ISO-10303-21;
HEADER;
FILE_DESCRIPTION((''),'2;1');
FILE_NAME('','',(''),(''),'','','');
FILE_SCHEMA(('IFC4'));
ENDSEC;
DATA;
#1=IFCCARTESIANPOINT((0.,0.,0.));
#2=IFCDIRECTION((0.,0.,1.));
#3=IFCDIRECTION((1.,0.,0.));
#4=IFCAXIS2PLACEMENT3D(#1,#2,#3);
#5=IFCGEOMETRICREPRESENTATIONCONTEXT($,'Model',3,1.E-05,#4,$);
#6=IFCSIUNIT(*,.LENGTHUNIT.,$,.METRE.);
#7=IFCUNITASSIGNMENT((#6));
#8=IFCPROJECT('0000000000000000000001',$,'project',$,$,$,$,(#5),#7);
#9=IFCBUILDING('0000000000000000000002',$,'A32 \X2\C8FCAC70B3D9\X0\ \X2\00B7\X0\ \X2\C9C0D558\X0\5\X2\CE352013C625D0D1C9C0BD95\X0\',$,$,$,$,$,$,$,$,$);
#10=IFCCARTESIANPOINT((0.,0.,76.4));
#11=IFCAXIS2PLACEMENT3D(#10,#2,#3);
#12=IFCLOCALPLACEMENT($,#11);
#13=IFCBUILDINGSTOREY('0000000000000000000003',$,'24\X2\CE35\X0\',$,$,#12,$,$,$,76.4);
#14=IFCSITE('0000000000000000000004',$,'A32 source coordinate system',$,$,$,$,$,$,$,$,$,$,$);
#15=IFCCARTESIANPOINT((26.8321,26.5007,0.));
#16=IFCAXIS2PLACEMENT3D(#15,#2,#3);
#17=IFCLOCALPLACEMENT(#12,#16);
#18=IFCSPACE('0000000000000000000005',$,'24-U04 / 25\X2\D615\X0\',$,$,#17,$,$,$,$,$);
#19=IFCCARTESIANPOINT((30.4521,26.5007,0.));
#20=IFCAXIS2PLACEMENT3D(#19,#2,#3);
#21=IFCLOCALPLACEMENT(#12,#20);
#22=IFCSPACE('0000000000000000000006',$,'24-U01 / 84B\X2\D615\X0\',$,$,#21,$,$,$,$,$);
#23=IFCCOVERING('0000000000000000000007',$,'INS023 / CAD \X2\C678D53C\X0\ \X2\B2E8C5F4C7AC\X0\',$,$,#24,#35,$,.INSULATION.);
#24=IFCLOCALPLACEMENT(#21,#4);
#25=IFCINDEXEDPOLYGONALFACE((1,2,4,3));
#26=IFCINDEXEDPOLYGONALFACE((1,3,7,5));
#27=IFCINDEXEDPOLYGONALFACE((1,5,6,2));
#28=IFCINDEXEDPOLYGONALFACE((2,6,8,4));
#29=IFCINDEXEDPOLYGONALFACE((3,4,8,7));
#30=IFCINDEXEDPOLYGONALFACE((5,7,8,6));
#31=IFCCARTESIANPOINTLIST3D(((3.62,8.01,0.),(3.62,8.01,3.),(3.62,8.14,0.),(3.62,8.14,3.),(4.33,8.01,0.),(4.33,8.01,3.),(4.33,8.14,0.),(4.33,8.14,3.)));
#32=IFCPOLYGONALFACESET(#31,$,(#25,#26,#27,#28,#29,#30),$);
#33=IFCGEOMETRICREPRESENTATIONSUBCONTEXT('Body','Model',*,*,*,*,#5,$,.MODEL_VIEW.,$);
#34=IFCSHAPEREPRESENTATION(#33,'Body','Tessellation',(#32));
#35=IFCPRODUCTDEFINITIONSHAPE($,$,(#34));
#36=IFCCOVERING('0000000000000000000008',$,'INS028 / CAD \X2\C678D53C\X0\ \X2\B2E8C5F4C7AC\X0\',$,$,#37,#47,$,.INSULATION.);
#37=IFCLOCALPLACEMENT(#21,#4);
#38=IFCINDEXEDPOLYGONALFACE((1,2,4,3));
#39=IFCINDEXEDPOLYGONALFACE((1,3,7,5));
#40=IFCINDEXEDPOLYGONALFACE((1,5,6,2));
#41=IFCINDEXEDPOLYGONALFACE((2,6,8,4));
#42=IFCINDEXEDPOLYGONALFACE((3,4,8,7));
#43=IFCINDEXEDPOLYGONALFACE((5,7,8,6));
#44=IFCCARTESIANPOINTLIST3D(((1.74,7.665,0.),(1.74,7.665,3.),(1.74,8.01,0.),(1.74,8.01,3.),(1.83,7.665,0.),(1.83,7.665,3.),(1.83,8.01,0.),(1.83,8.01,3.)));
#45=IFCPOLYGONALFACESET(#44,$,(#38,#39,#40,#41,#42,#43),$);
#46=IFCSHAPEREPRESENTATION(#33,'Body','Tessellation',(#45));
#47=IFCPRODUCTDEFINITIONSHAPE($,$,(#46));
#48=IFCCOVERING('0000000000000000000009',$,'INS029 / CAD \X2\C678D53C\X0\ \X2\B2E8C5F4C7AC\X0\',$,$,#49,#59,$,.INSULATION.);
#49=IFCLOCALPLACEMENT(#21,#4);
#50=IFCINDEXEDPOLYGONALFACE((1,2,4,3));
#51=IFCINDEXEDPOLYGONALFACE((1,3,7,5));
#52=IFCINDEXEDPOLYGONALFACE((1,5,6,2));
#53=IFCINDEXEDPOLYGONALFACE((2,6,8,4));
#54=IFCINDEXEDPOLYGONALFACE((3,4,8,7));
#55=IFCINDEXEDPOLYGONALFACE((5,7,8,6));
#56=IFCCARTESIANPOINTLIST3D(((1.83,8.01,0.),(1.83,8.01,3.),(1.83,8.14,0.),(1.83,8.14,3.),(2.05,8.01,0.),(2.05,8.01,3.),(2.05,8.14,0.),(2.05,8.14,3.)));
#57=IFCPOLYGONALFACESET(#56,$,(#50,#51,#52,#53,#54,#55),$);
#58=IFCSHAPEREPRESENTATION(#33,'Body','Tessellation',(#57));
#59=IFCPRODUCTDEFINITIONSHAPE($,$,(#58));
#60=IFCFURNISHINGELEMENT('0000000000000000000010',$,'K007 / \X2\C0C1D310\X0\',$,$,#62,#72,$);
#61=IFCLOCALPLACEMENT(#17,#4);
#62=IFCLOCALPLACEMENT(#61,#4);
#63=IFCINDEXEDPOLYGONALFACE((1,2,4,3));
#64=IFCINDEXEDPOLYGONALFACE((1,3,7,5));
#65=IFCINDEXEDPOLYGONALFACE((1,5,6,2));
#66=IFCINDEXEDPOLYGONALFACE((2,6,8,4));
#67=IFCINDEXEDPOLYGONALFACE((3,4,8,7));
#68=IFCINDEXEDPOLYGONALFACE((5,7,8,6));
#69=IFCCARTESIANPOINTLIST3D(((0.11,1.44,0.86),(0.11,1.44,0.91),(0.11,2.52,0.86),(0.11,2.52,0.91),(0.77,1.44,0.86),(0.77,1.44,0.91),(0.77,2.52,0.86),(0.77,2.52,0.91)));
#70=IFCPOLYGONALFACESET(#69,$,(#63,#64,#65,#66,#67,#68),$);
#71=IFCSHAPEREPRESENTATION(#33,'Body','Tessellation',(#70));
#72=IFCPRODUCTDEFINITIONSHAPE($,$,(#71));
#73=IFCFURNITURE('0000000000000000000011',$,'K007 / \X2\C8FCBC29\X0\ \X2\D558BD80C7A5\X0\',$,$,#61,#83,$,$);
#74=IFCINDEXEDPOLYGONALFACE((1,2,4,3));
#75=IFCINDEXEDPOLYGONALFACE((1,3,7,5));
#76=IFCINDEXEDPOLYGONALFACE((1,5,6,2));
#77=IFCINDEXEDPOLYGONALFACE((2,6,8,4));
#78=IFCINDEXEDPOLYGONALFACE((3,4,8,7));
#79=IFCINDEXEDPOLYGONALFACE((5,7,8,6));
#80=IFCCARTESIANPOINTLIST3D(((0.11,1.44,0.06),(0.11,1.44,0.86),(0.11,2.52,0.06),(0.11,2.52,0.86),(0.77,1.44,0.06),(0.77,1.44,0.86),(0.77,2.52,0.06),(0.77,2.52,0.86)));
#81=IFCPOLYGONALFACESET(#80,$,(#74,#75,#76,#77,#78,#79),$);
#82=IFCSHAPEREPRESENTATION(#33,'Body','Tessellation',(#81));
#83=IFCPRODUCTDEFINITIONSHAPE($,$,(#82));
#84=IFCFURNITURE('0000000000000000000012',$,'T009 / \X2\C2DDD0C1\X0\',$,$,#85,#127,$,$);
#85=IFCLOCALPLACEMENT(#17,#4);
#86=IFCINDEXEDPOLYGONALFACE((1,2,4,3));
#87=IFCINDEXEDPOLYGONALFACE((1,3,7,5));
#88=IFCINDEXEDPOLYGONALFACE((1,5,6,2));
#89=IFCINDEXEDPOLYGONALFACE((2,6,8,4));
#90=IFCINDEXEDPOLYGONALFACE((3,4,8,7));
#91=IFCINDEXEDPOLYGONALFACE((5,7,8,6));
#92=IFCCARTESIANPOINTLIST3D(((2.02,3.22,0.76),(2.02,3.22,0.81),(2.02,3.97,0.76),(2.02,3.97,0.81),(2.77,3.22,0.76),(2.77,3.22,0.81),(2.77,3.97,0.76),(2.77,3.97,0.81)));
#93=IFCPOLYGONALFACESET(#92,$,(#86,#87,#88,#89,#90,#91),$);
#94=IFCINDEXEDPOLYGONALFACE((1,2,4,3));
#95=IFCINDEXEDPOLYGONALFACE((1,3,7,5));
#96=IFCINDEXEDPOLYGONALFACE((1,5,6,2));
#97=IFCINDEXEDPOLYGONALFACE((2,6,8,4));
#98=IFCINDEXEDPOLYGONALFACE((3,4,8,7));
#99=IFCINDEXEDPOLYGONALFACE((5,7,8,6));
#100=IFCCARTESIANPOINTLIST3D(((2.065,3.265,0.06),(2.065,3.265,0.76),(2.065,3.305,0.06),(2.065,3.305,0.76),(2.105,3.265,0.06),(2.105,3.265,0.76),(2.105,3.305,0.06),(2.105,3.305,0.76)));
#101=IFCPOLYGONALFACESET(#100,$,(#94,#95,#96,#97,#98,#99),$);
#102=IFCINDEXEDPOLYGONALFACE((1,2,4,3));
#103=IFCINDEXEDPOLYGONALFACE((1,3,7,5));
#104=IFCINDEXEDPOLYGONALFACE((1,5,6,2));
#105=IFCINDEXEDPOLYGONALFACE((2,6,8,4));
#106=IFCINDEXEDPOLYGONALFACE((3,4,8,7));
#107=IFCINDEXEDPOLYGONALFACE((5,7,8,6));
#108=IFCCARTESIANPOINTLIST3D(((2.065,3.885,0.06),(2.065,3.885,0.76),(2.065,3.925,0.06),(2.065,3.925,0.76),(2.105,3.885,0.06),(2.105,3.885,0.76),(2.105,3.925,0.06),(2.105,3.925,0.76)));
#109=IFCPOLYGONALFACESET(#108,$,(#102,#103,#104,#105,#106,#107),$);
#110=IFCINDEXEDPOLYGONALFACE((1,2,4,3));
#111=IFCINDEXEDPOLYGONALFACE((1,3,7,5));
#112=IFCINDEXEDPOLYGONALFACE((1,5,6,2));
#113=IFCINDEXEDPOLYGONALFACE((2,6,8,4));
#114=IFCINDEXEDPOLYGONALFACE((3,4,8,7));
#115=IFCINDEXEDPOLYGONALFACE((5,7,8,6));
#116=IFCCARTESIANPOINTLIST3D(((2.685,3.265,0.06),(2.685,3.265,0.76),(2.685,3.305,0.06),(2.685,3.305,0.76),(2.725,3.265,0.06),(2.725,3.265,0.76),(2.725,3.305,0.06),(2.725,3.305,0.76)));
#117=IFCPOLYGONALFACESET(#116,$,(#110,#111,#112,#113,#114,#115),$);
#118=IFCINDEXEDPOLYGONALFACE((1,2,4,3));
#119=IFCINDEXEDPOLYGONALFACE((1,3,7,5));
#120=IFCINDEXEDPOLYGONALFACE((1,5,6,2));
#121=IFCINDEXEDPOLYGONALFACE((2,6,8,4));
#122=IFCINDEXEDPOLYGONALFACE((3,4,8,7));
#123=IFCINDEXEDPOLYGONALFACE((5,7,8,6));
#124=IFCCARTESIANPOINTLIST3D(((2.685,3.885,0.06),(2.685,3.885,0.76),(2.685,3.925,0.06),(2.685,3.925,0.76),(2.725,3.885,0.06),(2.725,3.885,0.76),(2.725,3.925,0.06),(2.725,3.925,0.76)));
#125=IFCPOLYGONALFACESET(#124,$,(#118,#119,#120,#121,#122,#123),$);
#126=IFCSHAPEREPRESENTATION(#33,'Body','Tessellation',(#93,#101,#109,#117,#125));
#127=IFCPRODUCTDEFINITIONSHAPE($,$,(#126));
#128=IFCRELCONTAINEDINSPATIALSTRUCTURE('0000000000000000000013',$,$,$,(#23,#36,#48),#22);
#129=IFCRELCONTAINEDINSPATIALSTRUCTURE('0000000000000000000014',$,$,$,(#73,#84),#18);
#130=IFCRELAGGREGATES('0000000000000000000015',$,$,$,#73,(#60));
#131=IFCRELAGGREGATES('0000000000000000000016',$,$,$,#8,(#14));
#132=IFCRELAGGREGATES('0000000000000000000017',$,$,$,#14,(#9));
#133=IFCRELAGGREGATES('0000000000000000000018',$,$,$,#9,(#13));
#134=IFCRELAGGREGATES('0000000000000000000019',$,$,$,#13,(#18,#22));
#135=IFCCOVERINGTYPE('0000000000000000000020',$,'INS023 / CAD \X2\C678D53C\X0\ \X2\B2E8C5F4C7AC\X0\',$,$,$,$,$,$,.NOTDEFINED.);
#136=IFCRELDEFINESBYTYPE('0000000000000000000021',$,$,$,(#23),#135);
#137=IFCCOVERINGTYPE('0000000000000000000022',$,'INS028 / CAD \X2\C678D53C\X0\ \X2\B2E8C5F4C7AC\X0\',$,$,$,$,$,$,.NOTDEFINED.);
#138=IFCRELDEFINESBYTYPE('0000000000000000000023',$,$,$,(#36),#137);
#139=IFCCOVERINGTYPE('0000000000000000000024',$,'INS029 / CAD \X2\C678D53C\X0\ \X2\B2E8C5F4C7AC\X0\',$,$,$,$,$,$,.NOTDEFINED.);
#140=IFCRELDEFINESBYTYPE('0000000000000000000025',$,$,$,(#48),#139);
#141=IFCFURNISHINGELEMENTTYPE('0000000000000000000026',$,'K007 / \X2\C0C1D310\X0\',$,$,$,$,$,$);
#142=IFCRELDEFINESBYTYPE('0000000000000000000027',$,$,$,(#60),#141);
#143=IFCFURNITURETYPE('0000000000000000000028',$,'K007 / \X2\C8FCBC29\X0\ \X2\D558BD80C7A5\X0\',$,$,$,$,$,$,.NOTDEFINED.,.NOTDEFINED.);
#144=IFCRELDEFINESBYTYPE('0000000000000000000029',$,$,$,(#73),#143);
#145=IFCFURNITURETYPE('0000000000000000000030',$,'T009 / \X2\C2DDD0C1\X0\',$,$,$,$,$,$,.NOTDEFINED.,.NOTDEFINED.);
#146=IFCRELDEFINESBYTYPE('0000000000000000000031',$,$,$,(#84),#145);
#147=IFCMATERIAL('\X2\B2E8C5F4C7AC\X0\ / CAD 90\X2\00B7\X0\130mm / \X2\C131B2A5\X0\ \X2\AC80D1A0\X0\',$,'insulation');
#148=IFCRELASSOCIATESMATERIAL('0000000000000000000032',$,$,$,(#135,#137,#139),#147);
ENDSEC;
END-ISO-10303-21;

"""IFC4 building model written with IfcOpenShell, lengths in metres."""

from ifc_helpers import new_model, si_unit, frame, origin, origin_with_axes, place, context, subcontext, project, spatial, polyline, outline, extrude, source, transform, mapped, material, type_object, type_shapes, element, aggregate, save


model = new_model("IFC4")

# Units and contexts
model_context = context("Model", 3, precision=1e-05, world=origin_with_axes())
body_context = subcontext(model_context, "Body", "Model", "MODEL_VIEW")
ifc_project = project(units=[si_unit("LENGTHUNIT", "METRE")], contexts=[model_context])

# Site, building, storey, space
site = spatial("IfcSite", under=ifc_project, Name="A32 source coordinate system")
building = spatial("IfcBuilding", under=site, Name="A32 주거동 · 지하5층–옥탑지붕")
storey_placement = place(None, frame((0.0, 0.0, 76.4), z_axis=(0.0, 0.0, 1.0), x_axis=(1.0, 0.0, 0.0)))
storey = spatial("IfcBuildingStorey", under=building, at=storey_placement, Name="24층", Elevation=76.4)
space_1_placement = place(storey_placement, frame((26.8321, 26.5007, 0.0), z_axis=(0.0, 0.0, 1.0), x_axis=(1.0, 0.0, 0.0)))
space_1 = spatial("IfcSpace", under=storey, at=space_1_placement, Name="24-U04 / 25형")

# Shared definitions
space_2_placement = place(storey_placement, frame((30.4521, 26.5007, 0.0), z_axis=(0.0, 0.0, 1.0), x_axis=(1.0, 0.0, 0.0)))
space_2 = spatial("IfcSpace", under=storey, at=space_2_placement, Name="24-U01 / 84B형")

# Coverings
ifc_material = material(Name="단열재 / CAD 90·130mm / 성능 검토", Category="insulation")
covering_type_1 = type_object("IfcCoveringType", Name="INS023 / CAD 외피 단열재", PredefinedType="NOTDEFINED", material=ifc_material)
shared_shape_1 = source(origin(), body_context, "Body", "SweptSolid", [
    extrude(outline(polyline([(4.33, 8.01), (3.62, 8.01), (3.62, 8.14), (4.33, 8.14), (4.33, 8.01)])), origin(), (0.0, 0.0, 1.0), 3.0),
])
type_shapes(covering_type_1, [shared_shape_1])
covering_1_placement = place(space_2_placement, origin_with_axes())
element("IfcCovering", 1, at=covering_1_placement, inside=space_2, type_object=covering_type_1, Name="INS023 / CAD 외피 단열재", PredefinedType="INSULATION", context=body_context, shape_type="MappedRepresentation", body=[
    mapped(shared_shape_1, transform((0.0, 0.0, 0.0), scale=1.0)),
])
covering_type_2 = type_object("IfcCoveringType", Name="INS028 / CAD 외피 단열재", PredefinedType="NOTDEFINED", material=ifc_material)
shared_shape_2 = source(origin(), body_context, "Body", "SweptSolid", [
    extrude(outline(polyline([(1.74, 8.01), (1.83, 8.01), (1.83, 7.665), (1.74, 7.665), (1.74, 8.01)])), origin(), (0.0, 0.0, 1.0), 3.0),
])
type_shapes(covering_type_2, [shared_shape_2])
covering_2_placement = place(space_2_placement, origin_with_axes())
element("IfcCovering", 2, at=covering_2_placement, inside=space_2, type_object=covering_type_2, Name="INS028 / CAD 외피 단열재", PredefinedType="INSULATION", context=body_context, shape_type="MappedRepresentation", body=[
    mapped(shared_shape_2, transform((0.0, 0.0, 0.0), scale=1.0)),
])
covering_type_3 = type_object("IfcCoveringType", Name="INS029 / CAD 외피 단열재", PredefinedType="NOTDEFINED", material=ifc_material)
shared_shape_3 = source(origin(), body_context, "Body", "SweptSolid", [
    extrude(outline(polyline([(1.83, 8.01), (1.83, 8.14), (2.05, 8.14), (2.05, 8.01), (1.83, 8.01)])), origin(), (0.0, 0.0, 1.0), 3.0),
])
type_shapes(covering_type_3, [shared_shape_3])
covering_3_placement = place(space_2_placement, origin_with_axes())
element("IfcCovering", 3, at=covering_3_placement, inside=space_2, type_object=covering_type_3, Name="INS029 / CAD 외피 단열재", PredefinedType="INSULATION", context=body_context, shape_type="MappedRepresentation", body=[
    mapped(shared_shape_3, transform((0.0, 0.0, 0.0), scale=1.0)),
])

# Furnishing element
furnishing_element_type_1 = type_object("IfcFurnishingElementType", Name="K007 / 상판")
shared_shape_4 = source(origin(), body_context, "Body", "SweptSolid", [
    extrude(outline(polyline([(0.77, 2.52), (0.77, 1.44), (0.11, 1.44), (0.11, 2.52), (0.77, 2.52)])), frame((0.0, 0.0, 0.86)), (0.0, 0.0, 1.0), 0.05),
])
type_shapes(furnishing_element_type_1, [shared_shape_4])
furniture_1_placement = place(space_1_placement, origin_with_axes())
furnishing_1_placement = place(furniture_1_placement, origin_with_axes())
furnishing_1 = element("IfcFurnishingElement", 4, at=furnishing_1_placement, type_object=furnishing_element_type_1, Name="K007 / 상판", context=body_context, shape_type="MappedRepresentation", body=[
    mapped(shared_shape_4, transform((0.0, 0.0, 0.0), scale=1.0)),
])

# Furniture
furniture_type_1 = type_object("IfcFurnitureType", Name="K007 / 주방 하부장", AssemblyPlace="NOTDEFINED", PredefinedType="NOTDEFINED")
shared_shape_5 = source(origin(), body_context, "Body", "SweptSolid", [
    extrude(outline(polyline([(0.11, 2.52), (0.77, 2.52), (0.77, 1.44), (0.11, 1.44), (0.11, 2.52)])), frame((0.0, 0.0, 0.06)), (0.0, 0.0, 1.0), 0.8),
])
type_shapes(furniture_type_1, [shared_shape_5])
furniture_1 = element("IfcFurniture", 5, at=furniture_1_placement, inside=space_1, type_object=furniture_type_1, Name="K007 / 주방 하부장", context=body_context, shape_type="MappedRepresentation", body=[
    mapped(shared_shape_5, transform((0.0, 0.0, 0.0), scale=1.0)),
])
aggregate(furniture_1, [furnishing_1])
furniture_type_2 = type_object("IfcFurnitureType", Name="T009 / 식탁", AssemblyPlace="NOTDEFINED", PredefinedType="NOTDEFINED")
shared_shape_6 = source(origin(), body_context, "Body", "SweptSolid", [
    extrude(outline(polyline([(2.77, 3.22), (2.02, 3.22), (2.02, 3.97), (2.77, 3.97), (2.77, 3.22)])), frame((0.0, 0.0, 0.76)), (0.0, 0.0, 1.0), 0.05),
    extrude(outline(polyline([(2.065, 3.265), (2.065, 3.305), (2.105, 3.305), (2.105, 3.265), (2.065, 3.265)])), frame((0.0, 0.0, 0.06)), (0.0, 0.0, 1.0), 0.7),
    extrude(outline(polyline([(2.065, 3.885), (2.065, 3.925), (2.105, 3.925), (2.105, 3.885), (2.065, 3.885)])), frame((0.0, 0.0, 0.06)), (0.0, 0.0, 1.0), 0.7),
    extrude(outline(polyline([(2.685, 3.265), (2.685, 3.305), (2.725, 3.305), (2.725, 3.265), (2.685, 3.265)])), frame((0.0, 0.0, 0.06)), (0.0, 0.0, 1.0), 0.7),
    extrude(outline(polyline([(2.685, 3.885), (2.685, 3.925), (2.725, 3.925), (2.725, 3.885), (2.685, 3.885)])), frame((0.0, 0.0, 0.06)), (0.0, 0.0, 1.0), 0.7),
])
type_shapes(furniture_type_2, [shared_shape_6])
furniture_2_placement = place(space_1_placement, origin_with_axes())
element("IfcFurniture", 6, at=furniture_2_placement, inside=space_1, type_object=furniture_type_2, Name="T009 / 식탁", context=body_context, shape_type="MappedRepresentation", body=[
    mapped(shared_shape_6, transform((0.0, 0.0, 0.0), scale=1.0)),
])

save(model, "model.ifc")
